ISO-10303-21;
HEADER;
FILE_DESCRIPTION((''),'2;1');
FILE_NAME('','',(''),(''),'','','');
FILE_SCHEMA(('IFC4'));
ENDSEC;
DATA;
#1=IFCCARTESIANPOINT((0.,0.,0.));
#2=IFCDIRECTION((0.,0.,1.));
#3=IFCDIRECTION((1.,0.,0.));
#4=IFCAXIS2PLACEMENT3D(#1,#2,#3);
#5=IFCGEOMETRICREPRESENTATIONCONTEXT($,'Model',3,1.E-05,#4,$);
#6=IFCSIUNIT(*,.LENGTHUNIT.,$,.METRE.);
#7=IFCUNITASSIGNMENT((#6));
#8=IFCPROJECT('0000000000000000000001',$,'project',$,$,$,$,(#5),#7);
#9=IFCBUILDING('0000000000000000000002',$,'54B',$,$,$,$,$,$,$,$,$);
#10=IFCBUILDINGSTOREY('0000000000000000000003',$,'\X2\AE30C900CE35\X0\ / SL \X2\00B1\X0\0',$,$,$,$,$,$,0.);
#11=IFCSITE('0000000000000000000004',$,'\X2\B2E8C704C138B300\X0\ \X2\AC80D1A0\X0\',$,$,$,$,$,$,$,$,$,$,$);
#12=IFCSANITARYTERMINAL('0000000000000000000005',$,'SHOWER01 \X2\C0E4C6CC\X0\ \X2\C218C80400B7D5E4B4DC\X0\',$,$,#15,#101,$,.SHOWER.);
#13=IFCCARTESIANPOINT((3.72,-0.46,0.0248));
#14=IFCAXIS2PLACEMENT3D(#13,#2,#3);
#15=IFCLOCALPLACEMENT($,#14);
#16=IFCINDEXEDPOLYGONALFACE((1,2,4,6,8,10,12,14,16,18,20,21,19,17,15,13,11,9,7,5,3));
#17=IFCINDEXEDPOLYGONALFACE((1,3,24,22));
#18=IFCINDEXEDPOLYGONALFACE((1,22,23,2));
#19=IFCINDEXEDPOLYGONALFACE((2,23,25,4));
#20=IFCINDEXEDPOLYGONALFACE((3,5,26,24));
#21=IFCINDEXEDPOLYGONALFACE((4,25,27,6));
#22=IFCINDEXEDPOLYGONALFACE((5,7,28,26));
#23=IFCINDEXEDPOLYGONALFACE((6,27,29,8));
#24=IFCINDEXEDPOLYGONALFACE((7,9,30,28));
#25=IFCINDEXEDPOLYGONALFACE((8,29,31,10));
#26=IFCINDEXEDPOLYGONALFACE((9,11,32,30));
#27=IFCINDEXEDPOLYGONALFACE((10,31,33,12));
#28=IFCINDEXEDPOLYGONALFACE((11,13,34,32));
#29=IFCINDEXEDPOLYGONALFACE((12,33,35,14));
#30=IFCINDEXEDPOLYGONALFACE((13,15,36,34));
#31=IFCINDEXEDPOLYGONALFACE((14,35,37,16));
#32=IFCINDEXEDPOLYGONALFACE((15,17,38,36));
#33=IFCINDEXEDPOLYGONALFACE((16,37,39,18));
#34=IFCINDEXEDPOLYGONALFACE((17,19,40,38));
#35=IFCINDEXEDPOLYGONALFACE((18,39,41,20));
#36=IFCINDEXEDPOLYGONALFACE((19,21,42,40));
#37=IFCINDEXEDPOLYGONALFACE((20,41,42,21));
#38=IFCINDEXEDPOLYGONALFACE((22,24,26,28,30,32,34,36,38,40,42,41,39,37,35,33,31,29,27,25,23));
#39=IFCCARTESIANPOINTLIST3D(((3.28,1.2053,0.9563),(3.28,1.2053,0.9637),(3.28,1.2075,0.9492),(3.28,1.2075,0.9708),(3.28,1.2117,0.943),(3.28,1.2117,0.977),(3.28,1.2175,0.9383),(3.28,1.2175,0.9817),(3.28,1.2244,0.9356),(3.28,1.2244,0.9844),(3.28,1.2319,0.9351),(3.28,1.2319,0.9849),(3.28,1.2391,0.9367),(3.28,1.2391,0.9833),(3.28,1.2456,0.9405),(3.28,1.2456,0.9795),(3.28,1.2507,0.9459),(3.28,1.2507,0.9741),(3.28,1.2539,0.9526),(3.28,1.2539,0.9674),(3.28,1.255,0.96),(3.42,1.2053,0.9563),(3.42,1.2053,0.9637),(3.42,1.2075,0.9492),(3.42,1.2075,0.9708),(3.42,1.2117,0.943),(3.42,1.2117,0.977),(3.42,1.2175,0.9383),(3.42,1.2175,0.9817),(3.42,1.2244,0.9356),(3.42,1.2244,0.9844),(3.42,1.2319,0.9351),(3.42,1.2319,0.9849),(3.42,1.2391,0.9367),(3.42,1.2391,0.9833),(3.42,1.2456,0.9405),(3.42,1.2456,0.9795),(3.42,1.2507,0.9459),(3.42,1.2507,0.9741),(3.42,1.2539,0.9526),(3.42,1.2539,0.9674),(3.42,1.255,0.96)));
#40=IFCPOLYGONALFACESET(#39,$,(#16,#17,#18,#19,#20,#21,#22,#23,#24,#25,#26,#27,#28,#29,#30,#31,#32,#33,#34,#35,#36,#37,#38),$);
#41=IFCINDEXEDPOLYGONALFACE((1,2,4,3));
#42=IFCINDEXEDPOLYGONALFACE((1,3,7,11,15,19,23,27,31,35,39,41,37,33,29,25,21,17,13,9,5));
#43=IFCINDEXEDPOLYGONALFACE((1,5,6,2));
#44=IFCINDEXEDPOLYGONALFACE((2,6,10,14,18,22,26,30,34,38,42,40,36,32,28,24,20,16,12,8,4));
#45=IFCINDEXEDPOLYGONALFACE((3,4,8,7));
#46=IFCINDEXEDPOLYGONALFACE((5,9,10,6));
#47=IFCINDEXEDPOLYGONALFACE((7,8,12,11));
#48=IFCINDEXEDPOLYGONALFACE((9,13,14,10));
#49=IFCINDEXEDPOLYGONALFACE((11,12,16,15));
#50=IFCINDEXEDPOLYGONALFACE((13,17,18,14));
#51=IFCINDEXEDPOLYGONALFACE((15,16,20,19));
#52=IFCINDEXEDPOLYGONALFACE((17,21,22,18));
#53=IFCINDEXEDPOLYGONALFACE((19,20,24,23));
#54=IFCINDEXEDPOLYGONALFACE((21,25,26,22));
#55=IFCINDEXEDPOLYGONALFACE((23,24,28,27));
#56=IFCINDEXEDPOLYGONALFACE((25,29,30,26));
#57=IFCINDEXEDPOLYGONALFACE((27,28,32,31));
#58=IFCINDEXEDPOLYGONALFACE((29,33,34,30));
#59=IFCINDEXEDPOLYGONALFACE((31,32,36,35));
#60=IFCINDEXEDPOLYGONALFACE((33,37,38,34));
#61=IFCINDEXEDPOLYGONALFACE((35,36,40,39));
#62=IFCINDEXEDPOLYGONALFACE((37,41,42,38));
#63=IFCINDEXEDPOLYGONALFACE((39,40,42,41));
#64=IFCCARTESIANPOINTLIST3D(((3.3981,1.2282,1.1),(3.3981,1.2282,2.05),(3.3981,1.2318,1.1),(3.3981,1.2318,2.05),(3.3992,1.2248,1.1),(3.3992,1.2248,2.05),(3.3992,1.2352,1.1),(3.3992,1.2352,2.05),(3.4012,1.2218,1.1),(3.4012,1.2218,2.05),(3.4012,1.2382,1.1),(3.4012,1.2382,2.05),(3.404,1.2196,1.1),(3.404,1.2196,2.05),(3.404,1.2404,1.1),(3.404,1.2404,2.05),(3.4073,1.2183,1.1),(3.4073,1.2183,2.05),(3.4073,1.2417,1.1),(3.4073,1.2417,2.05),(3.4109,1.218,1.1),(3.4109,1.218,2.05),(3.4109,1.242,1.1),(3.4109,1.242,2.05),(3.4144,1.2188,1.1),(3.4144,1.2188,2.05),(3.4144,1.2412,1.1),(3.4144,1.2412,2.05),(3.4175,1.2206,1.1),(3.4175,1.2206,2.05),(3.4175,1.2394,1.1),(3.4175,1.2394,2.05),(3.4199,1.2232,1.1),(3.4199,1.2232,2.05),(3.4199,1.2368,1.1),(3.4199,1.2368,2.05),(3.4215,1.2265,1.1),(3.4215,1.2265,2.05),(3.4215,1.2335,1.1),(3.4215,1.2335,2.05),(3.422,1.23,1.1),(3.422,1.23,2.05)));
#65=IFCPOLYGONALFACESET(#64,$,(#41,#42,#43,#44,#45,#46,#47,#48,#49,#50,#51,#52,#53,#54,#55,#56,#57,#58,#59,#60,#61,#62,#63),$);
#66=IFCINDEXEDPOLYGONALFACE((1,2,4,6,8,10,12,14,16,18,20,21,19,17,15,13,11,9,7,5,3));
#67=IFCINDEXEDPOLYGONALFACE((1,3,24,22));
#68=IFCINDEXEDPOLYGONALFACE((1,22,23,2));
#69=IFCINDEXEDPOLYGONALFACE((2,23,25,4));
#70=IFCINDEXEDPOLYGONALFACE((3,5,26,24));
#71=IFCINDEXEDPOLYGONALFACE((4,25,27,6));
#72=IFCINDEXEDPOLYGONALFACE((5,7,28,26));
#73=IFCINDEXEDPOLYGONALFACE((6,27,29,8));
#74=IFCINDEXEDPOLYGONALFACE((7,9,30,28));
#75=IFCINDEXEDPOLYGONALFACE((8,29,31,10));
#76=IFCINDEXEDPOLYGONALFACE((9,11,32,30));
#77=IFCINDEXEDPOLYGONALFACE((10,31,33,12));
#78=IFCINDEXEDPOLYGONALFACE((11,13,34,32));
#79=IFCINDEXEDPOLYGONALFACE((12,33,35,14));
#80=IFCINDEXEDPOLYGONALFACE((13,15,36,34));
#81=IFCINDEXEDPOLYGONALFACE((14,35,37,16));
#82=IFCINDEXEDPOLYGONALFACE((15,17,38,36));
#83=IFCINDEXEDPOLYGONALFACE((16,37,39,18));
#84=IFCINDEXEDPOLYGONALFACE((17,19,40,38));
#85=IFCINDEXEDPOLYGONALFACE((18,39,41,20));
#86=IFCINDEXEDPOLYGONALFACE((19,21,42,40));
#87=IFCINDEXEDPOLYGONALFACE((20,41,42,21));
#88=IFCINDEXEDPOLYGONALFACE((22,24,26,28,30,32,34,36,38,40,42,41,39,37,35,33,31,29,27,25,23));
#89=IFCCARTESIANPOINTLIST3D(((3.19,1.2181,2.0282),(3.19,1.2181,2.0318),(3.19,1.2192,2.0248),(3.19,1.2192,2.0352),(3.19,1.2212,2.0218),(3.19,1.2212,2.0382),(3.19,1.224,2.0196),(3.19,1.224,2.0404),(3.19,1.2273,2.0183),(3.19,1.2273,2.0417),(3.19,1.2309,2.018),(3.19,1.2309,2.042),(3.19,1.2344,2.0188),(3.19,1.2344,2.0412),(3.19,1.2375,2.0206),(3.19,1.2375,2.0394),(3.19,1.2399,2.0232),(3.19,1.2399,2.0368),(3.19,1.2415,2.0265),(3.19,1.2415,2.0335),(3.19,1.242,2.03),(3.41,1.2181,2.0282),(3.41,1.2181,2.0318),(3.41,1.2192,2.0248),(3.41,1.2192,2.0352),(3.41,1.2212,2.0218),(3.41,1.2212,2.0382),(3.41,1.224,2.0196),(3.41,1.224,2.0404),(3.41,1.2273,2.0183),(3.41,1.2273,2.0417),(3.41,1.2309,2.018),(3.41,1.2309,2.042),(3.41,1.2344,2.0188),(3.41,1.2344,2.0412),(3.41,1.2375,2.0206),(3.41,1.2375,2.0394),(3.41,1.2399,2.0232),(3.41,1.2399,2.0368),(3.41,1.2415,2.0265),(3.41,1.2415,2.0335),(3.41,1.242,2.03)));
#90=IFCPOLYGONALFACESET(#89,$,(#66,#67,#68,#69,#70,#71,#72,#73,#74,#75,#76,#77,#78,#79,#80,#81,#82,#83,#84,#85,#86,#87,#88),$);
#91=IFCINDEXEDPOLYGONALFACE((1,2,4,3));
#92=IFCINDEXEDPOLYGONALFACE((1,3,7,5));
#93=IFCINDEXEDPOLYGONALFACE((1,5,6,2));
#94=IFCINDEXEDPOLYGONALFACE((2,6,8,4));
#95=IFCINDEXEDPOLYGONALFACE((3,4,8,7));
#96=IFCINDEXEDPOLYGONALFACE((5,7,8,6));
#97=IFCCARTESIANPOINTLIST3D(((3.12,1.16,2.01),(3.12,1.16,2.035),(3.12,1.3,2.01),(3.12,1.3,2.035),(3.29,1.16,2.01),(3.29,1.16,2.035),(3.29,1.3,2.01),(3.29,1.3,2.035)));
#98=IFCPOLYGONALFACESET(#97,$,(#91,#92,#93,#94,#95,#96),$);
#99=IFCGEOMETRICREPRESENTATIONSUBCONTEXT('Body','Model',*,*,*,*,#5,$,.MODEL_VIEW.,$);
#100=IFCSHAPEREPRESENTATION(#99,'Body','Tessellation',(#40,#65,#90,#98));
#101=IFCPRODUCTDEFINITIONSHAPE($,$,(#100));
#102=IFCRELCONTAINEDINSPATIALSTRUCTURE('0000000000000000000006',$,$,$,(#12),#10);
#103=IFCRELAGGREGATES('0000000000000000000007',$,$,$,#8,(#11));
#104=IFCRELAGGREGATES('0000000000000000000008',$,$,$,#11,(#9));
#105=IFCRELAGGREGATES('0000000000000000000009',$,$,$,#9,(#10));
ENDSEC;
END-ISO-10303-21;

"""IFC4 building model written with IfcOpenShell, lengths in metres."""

from ifc_helpers import new_model, si_unit, frame, origin_with_axes, place, context, subcontext, project, spatial, polyline, circle, outline, extrude, element, save


model = new_model("IFC4")

# Units and contexts
model_context = context("Model", 3, precision=1e-05, world=origin_with_axes())
body_context = subcontext(model_context, "Body", "Model", "MODEL_VIEW")
ifc_project = project(units=[si_unit("LENGTHUNIT", "METRE")], contexts=[model_context])

# Site, building, storey
site = spatial("IfcSite", under=ifc_project, Name="단위세대 검토")
building = spatial("IfcBuilding", under=site, Name="54B")
storey = spatial("IfcBuildingStorey", under=building, Name="기준층 / SL ±0", Elevation=0.0)

# Sanitary terminal
sanitary_terminal_1_placement = place(None, frame((3.72, -0.46, 0.0248), z_axis=(0.0, 0.0, 1.0), x_axis=(1.0, 0.0, 0.0)))
element("IfcSanitaryTerminal", 1, at=sanitary_terminal_1_placement, inside=storey, Name="SHOWER01 샤워 수전·헤드", PredefinedType="SHOWER", context=body_context, shape_type="SweptSolid", body=[
    extrude(circle(Radius=0.025), frame((3.42, 1.23, 0.96), z_axis=(-1.0, 0.0, 0.0), x_axis=(0.0, 1.0, 0.0)), (0.0, 0.0, 1.0), 0.14),
    extrude(circle(Radius=0.012), frame((3.41, 1.23, 1.1), z_axis=(0.0, 0.0, 1.0), x_axis=(1.0, 0.0, 0.0)), (0.0, 0.0, 1.0), 0.95),
    extrude(circle(Radius=0.012), frame((3.41, 1.23, 2.03), z_axis=(-1.0, 0.0, 0.0), x_axis=(0.0, 1.0, 0.0)), (0.0, 0.0, 1.0), 0.22),
    extrude(outline(polyline([(3.29, 1.16), (3.29, 1.3), (3.12, 1.3), (3.12, 1.16), (3.29, 1.16)])), frame((0.0, 0.0, 2.01)), (0.0, 0.0, 1.0), 0.025),
])

save(model, "model.ifc")
